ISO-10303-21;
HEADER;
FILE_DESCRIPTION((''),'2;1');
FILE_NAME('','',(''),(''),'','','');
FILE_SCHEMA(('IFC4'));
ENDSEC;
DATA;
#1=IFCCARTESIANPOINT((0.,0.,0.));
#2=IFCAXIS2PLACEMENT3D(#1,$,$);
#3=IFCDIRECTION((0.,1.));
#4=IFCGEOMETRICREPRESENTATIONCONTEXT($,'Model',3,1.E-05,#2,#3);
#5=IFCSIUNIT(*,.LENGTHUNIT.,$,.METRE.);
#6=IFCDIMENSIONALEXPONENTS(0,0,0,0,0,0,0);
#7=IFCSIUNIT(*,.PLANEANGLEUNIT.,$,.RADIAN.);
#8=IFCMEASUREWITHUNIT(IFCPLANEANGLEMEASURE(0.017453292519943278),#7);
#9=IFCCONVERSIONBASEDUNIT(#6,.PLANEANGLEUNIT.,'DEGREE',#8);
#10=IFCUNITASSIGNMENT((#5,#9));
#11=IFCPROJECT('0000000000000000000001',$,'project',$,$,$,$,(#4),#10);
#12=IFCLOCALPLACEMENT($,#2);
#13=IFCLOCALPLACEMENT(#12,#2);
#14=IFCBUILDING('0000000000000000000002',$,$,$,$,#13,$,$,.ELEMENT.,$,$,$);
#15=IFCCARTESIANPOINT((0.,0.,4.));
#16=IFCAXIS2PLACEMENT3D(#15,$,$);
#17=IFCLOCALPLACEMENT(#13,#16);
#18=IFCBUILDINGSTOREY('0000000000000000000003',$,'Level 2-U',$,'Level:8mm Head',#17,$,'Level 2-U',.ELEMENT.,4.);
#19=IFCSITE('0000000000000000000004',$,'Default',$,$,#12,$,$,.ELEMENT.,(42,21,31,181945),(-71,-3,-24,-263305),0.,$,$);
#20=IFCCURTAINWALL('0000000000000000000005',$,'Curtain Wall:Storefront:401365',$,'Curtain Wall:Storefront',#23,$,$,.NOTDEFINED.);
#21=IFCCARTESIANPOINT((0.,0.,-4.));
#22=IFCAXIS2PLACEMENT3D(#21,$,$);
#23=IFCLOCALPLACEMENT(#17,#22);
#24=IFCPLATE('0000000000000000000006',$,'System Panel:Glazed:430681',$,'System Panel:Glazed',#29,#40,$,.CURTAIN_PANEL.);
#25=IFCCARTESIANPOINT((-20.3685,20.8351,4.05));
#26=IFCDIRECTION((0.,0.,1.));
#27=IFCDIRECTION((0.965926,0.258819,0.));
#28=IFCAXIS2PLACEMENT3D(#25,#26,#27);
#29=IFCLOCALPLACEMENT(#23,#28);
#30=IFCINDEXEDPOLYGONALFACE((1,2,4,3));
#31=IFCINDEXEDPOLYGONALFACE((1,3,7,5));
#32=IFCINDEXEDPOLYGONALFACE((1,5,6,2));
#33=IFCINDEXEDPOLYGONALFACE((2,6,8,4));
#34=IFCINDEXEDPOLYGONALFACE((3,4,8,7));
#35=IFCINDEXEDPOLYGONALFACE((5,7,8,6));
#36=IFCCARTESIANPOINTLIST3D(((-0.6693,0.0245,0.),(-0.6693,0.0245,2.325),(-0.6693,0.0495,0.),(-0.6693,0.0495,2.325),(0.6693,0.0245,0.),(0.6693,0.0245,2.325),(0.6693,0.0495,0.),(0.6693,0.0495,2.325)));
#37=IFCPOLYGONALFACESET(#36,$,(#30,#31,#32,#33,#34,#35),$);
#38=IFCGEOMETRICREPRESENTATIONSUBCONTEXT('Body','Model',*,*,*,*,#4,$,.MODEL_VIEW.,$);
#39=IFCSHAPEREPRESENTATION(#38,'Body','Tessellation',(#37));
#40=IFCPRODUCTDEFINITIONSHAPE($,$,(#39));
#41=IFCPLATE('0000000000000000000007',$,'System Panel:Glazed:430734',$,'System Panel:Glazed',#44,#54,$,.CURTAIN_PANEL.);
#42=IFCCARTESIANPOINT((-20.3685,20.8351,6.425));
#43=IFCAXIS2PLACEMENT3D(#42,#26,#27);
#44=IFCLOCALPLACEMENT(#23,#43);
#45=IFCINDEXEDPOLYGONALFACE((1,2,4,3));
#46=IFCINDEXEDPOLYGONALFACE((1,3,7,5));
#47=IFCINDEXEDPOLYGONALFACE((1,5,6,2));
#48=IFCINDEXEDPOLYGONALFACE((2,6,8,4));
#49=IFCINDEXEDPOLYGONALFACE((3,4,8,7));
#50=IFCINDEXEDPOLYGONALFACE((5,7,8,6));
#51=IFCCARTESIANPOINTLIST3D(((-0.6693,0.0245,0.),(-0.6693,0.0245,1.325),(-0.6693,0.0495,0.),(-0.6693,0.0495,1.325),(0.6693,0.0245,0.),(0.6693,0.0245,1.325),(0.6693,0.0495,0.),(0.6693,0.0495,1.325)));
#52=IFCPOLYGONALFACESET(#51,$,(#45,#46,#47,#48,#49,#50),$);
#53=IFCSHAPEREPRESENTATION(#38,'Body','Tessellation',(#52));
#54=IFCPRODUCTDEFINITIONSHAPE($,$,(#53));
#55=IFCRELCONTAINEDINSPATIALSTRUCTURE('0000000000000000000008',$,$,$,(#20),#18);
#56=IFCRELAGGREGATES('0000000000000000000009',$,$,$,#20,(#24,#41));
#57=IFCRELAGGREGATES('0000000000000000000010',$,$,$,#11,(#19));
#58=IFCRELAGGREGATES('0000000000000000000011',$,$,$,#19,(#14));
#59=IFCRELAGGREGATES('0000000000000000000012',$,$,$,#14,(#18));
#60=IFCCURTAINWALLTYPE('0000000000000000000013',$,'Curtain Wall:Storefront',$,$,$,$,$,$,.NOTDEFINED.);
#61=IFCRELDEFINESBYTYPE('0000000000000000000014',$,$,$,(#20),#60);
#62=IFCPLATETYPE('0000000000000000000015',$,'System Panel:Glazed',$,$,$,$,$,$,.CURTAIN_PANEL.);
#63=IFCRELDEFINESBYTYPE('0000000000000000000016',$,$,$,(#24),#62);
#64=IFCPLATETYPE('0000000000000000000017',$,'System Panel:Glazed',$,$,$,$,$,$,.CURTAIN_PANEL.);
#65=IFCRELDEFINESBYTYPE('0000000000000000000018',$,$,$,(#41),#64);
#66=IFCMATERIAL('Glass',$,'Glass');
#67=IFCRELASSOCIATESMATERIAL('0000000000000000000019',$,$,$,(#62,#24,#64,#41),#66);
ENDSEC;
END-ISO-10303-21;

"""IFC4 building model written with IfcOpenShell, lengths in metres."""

from ifc_helpers import new_model, entity, si_unit, converted_unit, direction, frame, origin, place, context, subcontext, project, spatial, indexed_curve, outline, extrude, source, transform, mapped, material, type_object, type_shapes, element, aggregate, save


model = new_model("IFC4")

# Units and contexts
model_context = context("Model", 3, precision=1e-05, world=origin(), true_north=direction((0.0, 1.0)))
body_context = subcontext(model_context, "Body", "Model", "MODEL_VIEW")
ifc_project = project(units=[si_unit("LENGTHUNIT", "METRE"), converted_unit("PLANEANGLEUNIT", "DEGREE", entity("IfcPlaneAngleMeasure", 0.017453292519943278), si_unit("PLANEANGLEUNIT", "RADIAN"), dimensions=[0, 0, 0, 0, 0, 0, 0])], contexts=[model_context])

# Site, building, storey
site_placement = place(None, origin())
site = spatial("IfcSite", under=ifc_project, at=site_placement, Name="Default", CompositionType="ELEMENT", RefLatitude=(42, 21, 31, 181945), RefLongitude=(-71, -3, -24, -263305), RefElevation=0.0)
building_placement = place(site_placement, origin())
building = spatial("IfcBuilding", under=site, at=building_placement, CompositionType="ELEMENT")
storey_placement = place(building_placement, frame((0.0, 0.0, 4.0)))
storey = spatial("IfcBuildingStorey", under=building, at=storey_placement, Name="Level 2-U", ObjectType="Level:8mm Head", LongName="Level 2-U", CompositionType="ELEMENT", Elevation=4.0)

# Curtain wall, plates
curtain_wall_type = type_object("IfcCurtainWallType", Name="Curtain Wall:Storefront", PredefinedType="NOTDEFINED")
curtain_wall_placement = place(storey_placement, frame((0.0, 0.0, -4.0)))
curtain_wall = element("IfcCurtainWall", 1, at=curtain_wall_placement, inside=storey, type_object=curtain_wall_type, Name="Curtain Wall:Storefront:401365", ObjectType="Curtain Wall:Storefront", PredefinedType="NOTDEFINED")
ifc_material_1 = material(Name="Glass", Category="Glass")
plate_type_1 = type_object("IfcPlateType", Name="System Panel:Glazed", PredefinedType="CURTAIN_PANEL", material=ifc_material_1)
shared_shape_1 = source(origin(), body_context, "Body", "SweptSolid", [
    extrude(outline(indexed_curve([(-0.0125, -0.6693), (0.0125, -0.6693), (0.0125, 0.6693), (-0.0125, 0.6693), (-0.0125, -0.6693)], self_intersect=False)), frame((0.0, 0.037, 0.0), z_axis=(0.0, 0.0, 1.0), x_axis=(0.0, 1.0, 0.0)), (0.0, 0.0, 1.0), 2.325),
])
type_shapes(plate_type_1, [shared_shape_1])
plate_1_placement = place(curtain_wall_placement, frame((-20.3685, 20.8351, 4.05), z_axis=(0.0, 0.0, 1.0), x_axis=(0.965926, 0.258819, 0.0)))
plate_1 = element("IfcPlate", 2, at=plate_1_placement, type_object=plate_type_1, material=ifc_material_1, Name="System Panel:Glazed:430681", ObjectType="System Panel:Glazed", PredefinedType="CURTAIN_PANEL", context=body_context, shape_type="MappedRepresentation", body=[
    mapped(shared_shape_1, transform((0.0, 0.0, 0.0), scale=1.0)),
])
plate_type_2 = type_object("IfcPlateType", Name="System Panel:Glazed", PredefinedType="CURTAIN_PANEL", material=ifc_material_1)
shared_shape_2 = source(origin(), body_context, "Body", "SweptSolid", [
    extrude(outline(indexed_curve([(-0.0125, -0.6693), (0.0125, -0.6693), (0.0125, 0.6693), (-0.0125, 0.6693), (-0.0125, -0.6693)], self_intersect=False)), frame((0.0, 0.037, 0.0), z_axis=(0.0, 0.0, 1.0), x_axis=(0.0, 1.0, 0.0)), (0.0, 0.0, 1.0), 1.325),
])
type_shapes(plate_type_2, [shared_shape_2])
plate_2_placement = place(curtain_wall_placement, frame((-20.3685, 20.8351, 6.425), z_axis=(0.0, 0.0, 1.0), x_axis=(0.965926, 0.258819, 0.0)))
plate_2 = element("IfcPlate", 3, at=plate_2_placement, type_object=plate_type_2, material=ifc_material_1, Name="System Panel:Glazed:430734", ObjectType="System Panel:Glazed", PredefinedType="CURTAIN_PANEL", context=body_context, shape_type="MappedRepresentation", body=[
    mapped(shared_shape_2, transform((0.0, 0.0, 0.0), scale=1.0)),
])
aggregate(curtain_wall, [plate_1, plate_2])

save(model, "model.ifc")
